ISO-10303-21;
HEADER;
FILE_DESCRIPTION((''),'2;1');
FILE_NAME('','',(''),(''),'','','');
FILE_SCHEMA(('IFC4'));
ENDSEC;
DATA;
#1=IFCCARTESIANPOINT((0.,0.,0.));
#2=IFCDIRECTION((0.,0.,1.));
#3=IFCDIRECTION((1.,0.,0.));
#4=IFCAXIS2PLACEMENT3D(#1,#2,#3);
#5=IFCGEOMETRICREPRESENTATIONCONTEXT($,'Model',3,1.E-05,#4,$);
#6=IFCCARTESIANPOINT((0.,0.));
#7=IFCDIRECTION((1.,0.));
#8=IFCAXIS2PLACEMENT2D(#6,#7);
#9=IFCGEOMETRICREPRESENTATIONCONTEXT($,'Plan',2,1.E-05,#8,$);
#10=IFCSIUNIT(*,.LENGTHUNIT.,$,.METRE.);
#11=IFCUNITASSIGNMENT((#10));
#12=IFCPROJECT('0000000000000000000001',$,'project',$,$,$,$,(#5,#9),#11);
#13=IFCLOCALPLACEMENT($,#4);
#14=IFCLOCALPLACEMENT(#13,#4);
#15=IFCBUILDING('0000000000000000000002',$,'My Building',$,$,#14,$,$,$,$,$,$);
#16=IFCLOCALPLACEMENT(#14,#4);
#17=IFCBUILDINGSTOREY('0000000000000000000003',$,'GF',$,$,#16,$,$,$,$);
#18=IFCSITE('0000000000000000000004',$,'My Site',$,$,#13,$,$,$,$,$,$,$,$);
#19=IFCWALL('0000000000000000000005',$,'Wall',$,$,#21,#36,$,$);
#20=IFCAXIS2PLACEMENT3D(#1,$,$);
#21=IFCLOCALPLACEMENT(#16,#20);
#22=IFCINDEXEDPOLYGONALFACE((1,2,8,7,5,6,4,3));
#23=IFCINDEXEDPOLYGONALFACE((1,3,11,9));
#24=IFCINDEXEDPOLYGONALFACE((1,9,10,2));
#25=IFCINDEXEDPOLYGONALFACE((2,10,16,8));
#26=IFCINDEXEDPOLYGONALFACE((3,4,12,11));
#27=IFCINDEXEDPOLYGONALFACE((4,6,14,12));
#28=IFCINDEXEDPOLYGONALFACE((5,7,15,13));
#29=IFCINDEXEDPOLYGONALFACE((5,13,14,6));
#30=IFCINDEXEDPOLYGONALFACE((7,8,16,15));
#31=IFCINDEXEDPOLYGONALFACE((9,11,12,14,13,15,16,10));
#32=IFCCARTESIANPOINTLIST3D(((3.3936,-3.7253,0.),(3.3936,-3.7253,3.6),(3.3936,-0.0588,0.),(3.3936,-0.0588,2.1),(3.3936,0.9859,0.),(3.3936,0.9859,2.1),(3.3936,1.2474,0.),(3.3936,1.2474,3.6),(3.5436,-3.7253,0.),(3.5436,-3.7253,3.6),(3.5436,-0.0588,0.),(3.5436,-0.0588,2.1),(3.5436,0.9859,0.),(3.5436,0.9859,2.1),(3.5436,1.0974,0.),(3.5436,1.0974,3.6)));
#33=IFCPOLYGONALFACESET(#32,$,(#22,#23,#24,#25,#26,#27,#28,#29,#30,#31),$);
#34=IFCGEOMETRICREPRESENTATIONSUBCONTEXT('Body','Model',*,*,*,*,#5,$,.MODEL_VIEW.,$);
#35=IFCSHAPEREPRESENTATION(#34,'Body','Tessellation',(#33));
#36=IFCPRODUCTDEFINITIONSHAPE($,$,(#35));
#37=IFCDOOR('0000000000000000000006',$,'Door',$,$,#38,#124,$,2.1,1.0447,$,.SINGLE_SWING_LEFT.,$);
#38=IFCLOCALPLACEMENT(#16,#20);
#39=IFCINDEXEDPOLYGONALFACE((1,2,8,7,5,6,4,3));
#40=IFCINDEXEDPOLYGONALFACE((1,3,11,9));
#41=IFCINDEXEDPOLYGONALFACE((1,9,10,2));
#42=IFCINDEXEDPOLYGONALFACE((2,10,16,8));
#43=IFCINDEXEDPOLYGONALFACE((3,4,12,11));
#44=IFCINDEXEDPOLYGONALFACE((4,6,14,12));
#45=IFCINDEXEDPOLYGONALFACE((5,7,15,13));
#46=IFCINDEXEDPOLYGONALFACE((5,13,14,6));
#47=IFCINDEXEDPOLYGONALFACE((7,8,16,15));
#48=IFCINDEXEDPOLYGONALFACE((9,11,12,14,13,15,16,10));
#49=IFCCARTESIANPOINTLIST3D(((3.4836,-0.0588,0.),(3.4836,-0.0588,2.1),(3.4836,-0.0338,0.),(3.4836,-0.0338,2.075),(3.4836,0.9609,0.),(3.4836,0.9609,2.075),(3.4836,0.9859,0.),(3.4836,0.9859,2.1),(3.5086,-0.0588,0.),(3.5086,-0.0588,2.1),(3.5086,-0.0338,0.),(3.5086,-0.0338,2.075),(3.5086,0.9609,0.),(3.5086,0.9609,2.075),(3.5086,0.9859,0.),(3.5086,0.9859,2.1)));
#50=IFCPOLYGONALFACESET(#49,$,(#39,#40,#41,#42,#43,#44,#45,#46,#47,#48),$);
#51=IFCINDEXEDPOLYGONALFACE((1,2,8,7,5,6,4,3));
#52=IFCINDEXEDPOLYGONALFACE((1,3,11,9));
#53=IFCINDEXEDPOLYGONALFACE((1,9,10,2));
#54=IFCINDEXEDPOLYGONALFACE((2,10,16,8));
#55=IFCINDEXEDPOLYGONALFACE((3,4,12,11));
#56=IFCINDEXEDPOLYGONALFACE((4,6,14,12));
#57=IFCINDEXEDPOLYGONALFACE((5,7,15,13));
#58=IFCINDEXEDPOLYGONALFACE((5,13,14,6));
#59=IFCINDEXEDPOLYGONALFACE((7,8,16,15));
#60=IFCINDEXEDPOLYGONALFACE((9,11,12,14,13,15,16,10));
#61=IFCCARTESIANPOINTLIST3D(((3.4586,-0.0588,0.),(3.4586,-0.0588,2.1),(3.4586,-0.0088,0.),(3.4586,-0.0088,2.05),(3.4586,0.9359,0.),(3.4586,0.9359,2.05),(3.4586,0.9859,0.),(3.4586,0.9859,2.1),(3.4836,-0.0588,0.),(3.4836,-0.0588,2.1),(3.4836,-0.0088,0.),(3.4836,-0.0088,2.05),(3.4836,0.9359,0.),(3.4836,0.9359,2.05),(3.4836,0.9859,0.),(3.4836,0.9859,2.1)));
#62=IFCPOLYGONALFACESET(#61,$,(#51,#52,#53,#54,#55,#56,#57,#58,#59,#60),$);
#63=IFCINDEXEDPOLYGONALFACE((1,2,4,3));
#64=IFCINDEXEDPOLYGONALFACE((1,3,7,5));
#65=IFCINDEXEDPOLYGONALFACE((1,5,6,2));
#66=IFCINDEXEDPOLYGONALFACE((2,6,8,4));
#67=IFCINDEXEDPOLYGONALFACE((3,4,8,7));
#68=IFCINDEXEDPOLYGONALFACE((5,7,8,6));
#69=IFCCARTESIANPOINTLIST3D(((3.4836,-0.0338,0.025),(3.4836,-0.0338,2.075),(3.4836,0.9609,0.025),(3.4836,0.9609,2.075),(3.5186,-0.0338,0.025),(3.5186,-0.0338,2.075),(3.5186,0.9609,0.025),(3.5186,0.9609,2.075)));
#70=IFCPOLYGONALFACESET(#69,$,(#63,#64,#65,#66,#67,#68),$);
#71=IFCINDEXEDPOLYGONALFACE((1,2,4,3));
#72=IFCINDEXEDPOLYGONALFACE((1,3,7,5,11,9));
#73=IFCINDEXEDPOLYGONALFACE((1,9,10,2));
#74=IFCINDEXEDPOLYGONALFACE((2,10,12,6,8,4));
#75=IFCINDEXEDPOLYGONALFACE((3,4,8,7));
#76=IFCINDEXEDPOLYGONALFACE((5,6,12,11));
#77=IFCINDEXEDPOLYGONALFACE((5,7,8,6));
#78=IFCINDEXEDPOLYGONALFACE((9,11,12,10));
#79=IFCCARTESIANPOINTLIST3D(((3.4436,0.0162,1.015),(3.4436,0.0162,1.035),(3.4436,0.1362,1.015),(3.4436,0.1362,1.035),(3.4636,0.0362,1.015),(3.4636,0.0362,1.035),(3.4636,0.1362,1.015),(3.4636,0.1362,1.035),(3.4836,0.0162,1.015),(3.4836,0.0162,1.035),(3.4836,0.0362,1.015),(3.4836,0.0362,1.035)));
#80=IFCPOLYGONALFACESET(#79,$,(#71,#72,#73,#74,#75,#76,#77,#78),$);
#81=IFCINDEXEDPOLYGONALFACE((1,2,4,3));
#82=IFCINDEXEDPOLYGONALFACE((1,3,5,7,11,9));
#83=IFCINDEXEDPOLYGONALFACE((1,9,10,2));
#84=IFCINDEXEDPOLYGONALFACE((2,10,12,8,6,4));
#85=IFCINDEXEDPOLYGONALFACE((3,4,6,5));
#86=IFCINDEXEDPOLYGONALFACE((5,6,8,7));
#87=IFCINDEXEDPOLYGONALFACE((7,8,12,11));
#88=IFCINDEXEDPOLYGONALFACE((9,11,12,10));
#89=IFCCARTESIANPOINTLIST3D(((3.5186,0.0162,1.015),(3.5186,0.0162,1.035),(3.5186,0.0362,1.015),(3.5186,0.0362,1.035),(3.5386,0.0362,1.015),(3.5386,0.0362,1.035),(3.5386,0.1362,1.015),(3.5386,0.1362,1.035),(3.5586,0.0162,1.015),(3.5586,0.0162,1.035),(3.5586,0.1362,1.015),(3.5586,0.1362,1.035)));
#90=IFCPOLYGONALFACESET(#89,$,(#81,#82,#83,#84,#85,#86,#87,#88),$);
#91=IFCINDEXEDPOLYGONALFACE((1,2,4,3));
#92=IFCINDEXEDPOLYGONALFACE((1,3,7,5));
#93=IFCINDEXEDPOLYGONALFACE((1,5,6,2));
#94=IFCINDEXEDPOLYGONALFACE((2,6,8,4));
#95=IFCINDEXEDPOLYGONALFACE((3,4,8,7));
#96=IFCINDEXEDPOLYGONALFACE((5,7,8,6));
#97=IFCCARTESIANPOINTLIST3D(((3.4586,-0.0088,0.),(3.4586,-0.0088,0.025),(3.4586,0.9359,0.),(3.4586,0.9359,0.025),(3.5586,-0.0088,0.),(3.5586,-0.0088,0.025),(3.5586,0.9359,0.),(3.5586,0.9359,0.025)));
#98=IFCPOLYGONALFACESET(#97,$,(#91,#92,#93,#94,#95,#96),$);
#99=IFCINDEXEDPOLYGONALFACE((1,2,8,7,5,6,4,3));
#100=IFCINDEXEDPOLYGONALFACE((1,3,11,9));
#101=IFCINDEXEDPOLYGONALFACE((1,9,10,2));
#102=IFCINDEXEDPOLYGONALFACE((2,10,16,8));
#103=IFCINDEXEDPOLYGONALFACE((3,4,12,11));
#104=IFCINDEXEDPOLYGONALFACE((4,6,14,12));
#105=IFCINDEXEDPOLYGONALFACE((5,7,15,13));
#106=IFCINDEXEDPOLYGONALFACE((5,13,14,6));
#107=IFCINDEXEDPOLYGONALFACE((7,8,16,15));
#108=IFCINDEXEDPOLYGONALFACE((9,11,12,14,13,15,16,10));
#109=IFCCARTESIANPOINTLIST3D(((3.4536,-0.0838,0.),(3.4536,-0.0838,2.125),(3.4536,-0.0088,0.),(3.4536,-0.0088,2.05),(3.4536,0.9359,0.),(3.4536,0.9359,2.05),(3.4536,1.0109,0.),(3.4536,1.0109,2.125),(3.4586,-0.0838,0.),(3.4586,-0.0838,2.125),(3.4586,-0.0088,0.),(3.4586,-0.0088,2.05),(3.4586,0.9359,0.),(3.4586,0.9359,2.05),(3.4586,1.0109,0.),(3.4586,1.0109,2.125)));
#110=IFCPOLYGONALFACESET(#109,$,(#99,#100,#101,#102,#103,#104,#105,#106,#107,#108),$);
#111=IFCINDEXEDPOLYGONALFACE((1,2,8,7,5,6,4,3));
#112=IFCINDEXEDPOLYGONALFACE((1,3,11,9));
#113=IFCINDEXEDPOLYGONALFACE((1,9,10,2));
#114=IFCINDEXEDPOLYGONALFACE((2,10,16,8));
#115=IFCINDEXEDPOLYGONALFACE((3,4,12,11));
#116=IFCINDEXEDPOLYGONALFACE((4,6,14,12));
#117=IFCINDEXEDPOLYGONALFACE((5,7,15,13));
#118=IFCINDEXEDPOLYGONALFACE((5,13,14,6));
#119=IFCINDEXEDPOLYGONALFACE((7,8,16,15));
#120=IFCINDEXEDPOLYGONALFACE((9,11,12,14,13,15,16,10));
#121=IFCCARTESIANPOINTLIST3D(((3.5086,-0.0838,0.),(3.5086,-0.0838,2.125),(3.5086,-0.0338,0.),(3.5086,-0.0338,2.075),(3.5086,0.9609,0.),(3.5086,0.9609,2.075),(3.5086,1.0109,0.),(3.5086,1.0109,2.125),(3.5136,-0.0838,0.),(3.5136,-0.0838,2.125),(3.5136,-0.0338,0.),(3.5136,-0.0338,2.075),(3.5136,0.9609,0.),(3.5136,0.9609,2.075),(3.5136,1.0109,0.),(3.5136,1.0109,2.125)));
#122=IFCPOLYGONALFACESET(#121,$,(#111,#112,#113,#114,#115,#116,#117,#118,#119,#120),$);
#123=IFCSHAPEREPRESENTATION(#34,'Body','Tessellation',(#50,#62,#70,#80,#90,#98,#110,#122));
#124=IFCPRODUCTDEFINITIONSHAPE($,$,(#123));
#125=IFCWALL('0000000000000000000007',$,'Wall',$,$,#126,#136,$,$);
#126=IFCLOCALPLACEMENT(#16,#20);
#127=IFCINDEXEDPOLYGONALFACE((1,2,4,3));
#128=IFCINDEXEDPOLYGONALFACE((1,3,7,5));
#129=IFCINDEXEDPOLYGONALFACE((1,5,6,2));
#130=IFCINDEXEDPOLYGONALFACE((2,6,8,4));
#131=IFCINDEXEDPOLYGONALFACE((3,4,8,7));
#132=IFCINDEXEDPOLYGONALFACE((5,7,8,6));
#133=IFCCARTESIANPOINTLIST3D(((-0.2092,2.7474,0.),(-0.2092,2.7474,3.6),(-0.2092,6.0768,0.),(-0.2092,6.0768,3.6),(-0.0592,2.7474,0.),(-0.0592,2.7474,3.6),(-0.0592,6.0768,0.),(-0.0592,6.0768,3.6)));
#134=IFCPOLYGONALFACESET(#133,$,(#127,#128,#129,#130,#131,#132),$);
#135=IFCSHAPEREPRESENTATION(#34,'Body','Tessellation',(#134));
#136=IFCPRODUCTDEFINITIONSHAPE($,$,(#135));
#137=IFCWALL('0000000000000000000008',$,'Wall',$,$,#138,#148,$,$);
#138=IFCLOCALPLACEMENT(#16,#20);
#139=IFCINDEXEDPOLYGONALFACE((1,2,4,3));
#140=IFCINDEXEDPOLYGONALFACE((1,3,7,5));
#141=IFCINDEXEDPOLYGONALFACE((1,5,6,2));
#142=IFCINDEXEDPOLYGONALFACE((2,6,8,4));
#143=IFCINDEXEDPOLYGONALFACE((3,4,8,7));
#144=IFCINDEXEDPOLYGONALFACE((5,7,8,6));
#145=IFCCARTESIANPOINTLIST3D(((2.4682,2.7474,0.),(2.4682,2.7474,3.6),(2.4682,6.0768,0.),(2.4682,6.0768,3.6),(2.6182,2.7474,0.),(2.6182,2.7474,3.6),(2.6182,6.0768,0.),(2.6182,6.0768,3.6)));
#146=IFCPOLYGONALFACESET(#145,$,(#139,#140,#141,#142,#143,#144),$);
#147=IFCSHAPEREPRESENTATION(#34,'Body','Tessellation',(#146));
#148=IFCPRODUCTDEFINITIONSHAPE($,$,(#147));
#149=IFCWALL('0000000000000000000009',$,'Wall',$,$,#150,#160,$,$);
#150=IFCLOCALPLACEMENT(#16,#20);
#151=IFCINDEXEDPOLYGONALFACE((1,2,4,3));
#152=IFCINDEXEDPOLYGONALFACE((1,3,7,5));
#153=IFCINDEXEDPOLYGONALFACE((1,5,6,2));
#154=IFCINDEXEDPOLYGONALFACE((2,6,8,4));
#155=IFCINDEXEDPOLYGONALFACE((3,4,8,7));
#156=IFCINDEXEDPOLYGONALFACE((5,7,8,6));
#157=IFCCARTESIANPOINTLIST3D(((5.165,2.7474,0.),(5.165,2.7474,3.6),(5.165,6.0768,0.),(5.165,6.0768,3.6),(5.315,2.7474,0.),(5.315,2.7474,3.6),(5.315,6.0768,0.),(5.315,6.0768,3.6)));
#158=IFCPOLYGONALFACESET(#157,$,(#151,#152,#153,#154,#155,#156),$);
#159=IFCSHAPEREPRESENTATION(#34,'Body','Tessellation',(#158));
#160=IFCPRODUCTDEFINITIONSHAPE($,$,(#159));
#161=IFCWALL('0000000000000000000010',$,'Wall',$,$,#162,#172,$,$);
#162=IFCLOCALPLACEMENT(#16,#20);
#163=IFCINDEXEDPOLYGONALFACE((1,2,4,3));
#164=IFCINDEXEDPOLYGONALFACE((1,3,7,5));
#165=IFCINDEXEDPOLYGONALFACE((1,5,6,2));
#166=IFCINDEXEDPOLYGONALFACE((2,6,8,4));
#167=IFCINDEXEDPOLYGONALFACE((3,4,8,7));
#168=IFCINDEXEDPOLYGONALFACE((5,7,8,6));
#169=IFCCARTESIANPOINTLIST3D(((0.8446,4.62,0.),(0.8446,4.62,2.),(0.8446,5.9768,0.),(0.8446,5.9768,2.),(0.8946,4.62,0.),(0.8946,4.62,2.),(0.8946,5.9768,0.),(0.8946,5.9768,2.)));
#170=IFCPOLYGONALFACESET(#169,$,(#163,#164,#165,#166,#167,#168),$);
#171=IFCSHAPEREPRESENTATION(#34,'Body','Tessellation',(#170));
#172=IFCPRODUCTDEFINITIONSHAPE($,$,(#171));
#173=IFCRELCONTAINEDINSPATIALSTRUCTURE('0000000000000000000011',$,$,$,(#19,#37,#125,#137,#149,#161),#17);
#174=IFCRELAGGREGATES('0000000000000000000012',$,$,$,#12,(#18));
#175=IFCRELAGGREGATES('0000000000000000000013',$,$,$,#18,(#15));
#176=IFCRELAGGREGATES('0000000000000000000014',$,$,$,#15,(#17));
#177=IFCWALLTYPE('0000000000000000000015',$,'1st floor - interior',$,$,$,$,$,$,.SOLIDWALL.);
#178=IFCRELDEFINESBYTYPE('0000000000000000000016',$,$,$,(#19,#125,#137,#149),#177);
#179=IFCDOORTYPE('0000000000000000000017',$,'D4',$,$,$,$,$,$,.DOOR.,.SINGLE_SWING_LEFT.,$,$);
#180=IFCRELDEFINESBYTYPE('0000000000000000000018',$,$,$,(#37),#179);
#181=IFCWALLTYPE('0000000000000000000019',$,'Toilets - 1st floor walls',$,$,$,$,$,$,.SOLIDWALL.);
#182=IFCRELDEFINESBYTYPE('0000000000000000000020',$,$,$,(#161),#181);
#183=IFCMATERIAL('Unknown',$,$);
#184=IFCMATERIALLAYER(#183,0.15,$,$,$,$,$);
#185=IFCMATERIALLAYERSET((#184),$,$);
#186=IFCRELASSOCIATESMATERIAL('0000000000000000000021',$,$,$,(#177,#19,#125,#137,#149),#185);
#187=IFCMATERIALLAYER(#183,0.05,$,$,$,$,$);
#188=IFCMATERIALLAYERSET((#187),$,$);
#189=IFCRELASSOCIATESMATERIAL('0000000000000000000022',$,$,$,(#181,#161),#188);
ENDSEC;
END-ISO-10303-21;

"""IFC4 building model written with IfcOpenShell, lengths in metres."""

from ifc_helpers import new_model, entity, si_unit, frame, origin_with_axes, origin_2d_with_axis, place, context, subcontext, project, spatial, line, indexed_curve, outline, extrude, shape, source, transform, mapped, material, layer, layer_set, layer_usage, type_object, type_shapes, element, fill, save


model = new_model("IFC4")

# Units and contexts
model_context = context("Model", 3, precision=1e-05, world=origin_with_axes())
plan_context = context("Plan", 2, precision=1e-05, world=origin_2d_with_axis())
body_context_1 = subcontext(model_context, "Body", "Model", "MODEL_VIEW")
body_context_2 = subcontext(plan_context, "Body", "Plan", "PLAN_VIEW")
ifc_project = project(units=[si_unit("LENGTHUNIT", "METRE")], contexts=[model_context, plan_context])

# Site, building, storey
site_placement = place(None, origin_with_axes())
site = spatial("IfcSite", under=ifc_project, at=site_placement, Name="My Site")
building_placement = place(site_placement, origin_with_axes())
building = spatial("IfcBuilding", under=site, at=building_placement, Name="My Building")
storey_placement = place(building_placement, origin_with_axes())
storey = spatial("IfcBuildingStorey", under=building, at=storey_placement, Name="GF")

# Shared definitions
ifc_material = material(Name="Unknown")

# Shared definitions
ifc_layer_1 = layer(ifc_material, 0.15)
ifc_layer_set_1 = layer_set([ifc_layer_1])
wall_type_1 = type_object("IfcWallType", Name="1st floor - interior", PredefinedType="SOLIDWALL", material=ifc_layer_set_1)

# Wall, opening, door
ifc_layer_usage_1 = layer_usage(ifc_layer_set_1, "AXIS2", "POSITIVE", 0.0)
wall_1_placement = place(storey_placement, frame((3.3936, 1.2474, 0.0), z_axis=(0.0, 0.0, 1.0), x_axis=(0.0, -1.0, 0.0)))
wall_1 = element("IfcWall", 1, at=wall_1_placement, inside=storey, type_object=wall_type_1, material=ifc_layer_usage_1, Name="Wall", context=body_context_1, shape_type="SweptSolid", body=[
    extrude(outline(indexed_curve([(0.0, 0.0), (0.15, 0.15), (4.9727, 0.15), (4.9727, 0.0)], segments=[line(1, 2, 3, 4, 1)])), origin_with_axes(), (0.0, 0.0, 1.0), 3.6),
])
shared_shape_1 = source(origin_with_axes(), body_context_1, "Body", "SweptSolid", [
    extrude(outline(indexed_curve([(0.0, 0.0), (1.0447, 0.0), (1.0447, 2.1), (0.0, 2.1)], segments=[line(1, 2, 3, 4, 1)])), frame((0.0, -0.6, 0.0), z_axis=(0.0, -1.0, 0.0), x_axis=(1.0, 0.0, 0.0)), (0.0, 0.0, -1.0), 1.2),
])
opening_1_placement = place(wall_1_placement, frame((0.2615, 0.065, 0.0), z_axis=(0.0, 0.0, 1.0), x_axis=(1.0, 0.0, 0.0)))
opening_1 = element("IfcOpeningElement", 2, at=opening_1_placement, cuts=wall_1, PredefinedType="OPENING", context=body_context_1, shape_type="MappedRepresentation", body=[
    mapped(shared_shape_1, transform((0.0, 0.0, 0.0), x_axis=(1.0, 0.0, 0.0), y_axis=(0.0, 1.0, 0.0), z_axis=(0.0, 0.0, 1.0), scale=1.0)),
])
door_type_1 = type_object("IfcDoorType", Name="D4", OperationType="SINGLE_SWING_LEFT", PredefinedType="DOOR")
shared_shape_2 = source(origin_with_axes(), body_context_1, "Body", "SweptSolid", [
    extrude(outline(indexed_curve([(0.0, 0.0), (0.0, 2.1), (1.0447, 2.1), (1.0447, 0.0), (1.0197, 0.0), (1.0197, 2.075), (0.025, 2.075), (0.025, 0.0)], segments=[line(1, 2, 3, 4, 5, 6, 7, 8, 1)])), frame((0.0, 0.025, 0.0), z_axis=(0.0, -1.0, 0.0), x_axis=(1.0, 0.0, 0.0)), (0.0, 0.0, -1.0), 0.025),
    extrude(outline(indexed_curve([(0.0, 0.0), (0.0, 2.1), (1.0447, 2.1), (1.0447, 0.0), (0.9947, 0.0), (0.9947, 2.05), (0.05, 2.05), (0.05, 0.0)], segments=[line(1, 2, 3, 4, 5, 6, 7, 8, 1)])), frame((0.0, 0.0, 0.0), z_axis=(0.0, -1.0, 0.0), x_axis=(1.0, 0.0, 0.0)), (0.0, 0.0, -1.0), 0.025),
    extrude(outline(indexed_curve([(0.0, 0.0), (0.9947, 0.0), (0.9947, 0.035), (0.0, 0.035)], segments=[line(1, 2, 3, 4, 1)])), frame((0.025, 0.025, 0.025), z_axis=(0.0, 0.0, 1.0), x_axis=(1.0, 0.0, 0.0)), (0.0, 0.0, 1.0), 2.05),
    extrude(outline(indexed_curve([(0.0, 0.0), (0.0, -0.04), (-0.12, -0.04), (-0.12, -0.02), (-0.02, -0.02), (-0.02, 0.0)], segments=[line(1, 2, 3, 4, 5, 6, 1)])), frame((0.9697, 0.025, 1.015), z_axis=(0.0, 0.0, 1.0), x_axis=(1.0, 0.0, 0.0)), (0.0, 0.0, 1.0), 0.02),
    extrude(outline(indexed_curve([(0.0, 0.0), (0.0, 0.04), (-0.12, 0.04), (-0.12, 0.02), (-0.02, 0.02), (-0.02, 0.0)], segments=[line(1, 2, 3, 4, 5, 6, 1)])), frame((0.9697, 0.06, 1.015), z_axis=(0.0, 0.0, 1.0), x_axis=(1.0, 0.0, 0.0)), (0.0, 0.0, 1.0), 0.02),
    extrude(outline(indexed_curve([(0.0, 0.0), (0.9447, 0.0), (0.9447, 0.1), (0.0, 0.1)], segments=[line(1, 2, 3, 4, 1)])), frame((0.05, 0.0, 0.0), z_axis=(0.0, 0.0, 1.0), x_axis=(1.0, 0.0, 0.0)), (0.0, 0.0, 1.0), 0.025),
    extrude(outline(indexed_curve([(0.0, 0.0), (0.0, 2.125), (1.0947, 2.125), (1.0947, 0.0), (1.0197, 0.0), (1.0197, 2.05), (0.075, 2.05), (0.075, 0.0)], segments=[line(1, 2, 3, 4, 5, 6, 7, 8, 1)])), frame((-0.025, -0.005, 0.0), z_axis=(0.0, -1.0, 0.0), x_axis=(1.0, 0.0, 0.0)), (0.0, 0.0, -1.0), 0.005),
    extrude(outline(indexed_curve([(0.0, 0.0), (0.0, 2.125), (1.0947, 2.125), (1.0947, 0.0), (1.0447, 0.0), (1.0447, 2.075), (0.05, 2.075), (0.05, 0.0)], segments=[line(1, 2, 3, 4, 5, 6, 7, 8, 1)])), frame((-0.025, 0.05, 0.0), z_axis=(0.0, -1.0, 0.0), x_axis=(1.0, 0.0, 0.0)), (0.0, 0.0, -1.0), 0.005),
])
shared_shape_3 = source(origin_with_axes(), body_context_2, "Body", "Curve2D", [
    entity("IfcIndexedPolyCurve", entity("IfcCartesianPointList2D", [[0.0, 0.0], [0.0, 0.05], [0.025, 0.05], [0.025, 0.025], [0.05, 0.025], [0.05, 0.0]]), [entity("IfcLineIndex", [1, 2, 3, 4, 5, 6, 1])]),
    entity("IfcIndexedPolyCurve", entity("IfcCartesianPointList2D", [[1.0447, 0.0], [1.0447, 0.05], [1.0197, 0.05], [1.0197, 0.025], [0.9947, 0.025], [0.9947, 0.0]]), [entity("IfcLineIndex", [1, 2, 3, 4, 5, 6, 1])]),
    entity("IfcTrimmedCurve", entity("IfcEllipse", entity("IfcAxis2Placement2D", entity("IfcCartesianPoint", [0.06, 0.05]), entity("IfcDirection", [1.0, 0.0])), 0.9597, 0.9947), [entity("IfcCartesianPoint", [1.0197, 0.05])], [entity("IfcCartesianPoint", [0.06, 1.0447])], True, "CARTESIAN"),
    entity("IfcIndexedPolyCurve", entity("IfcCartesianPointList2D", [[0.025, 0.05], [0.06, 0.05], [0.06, 1.0447], [0.025, 1.0447]]), [entity("IfcLineIndex", [1, 2, 3, 4, 1])]),
])
type_shapes(door_type_1, [shared_shape_2, shared_shape_3])
door_1_placement = place(opening_1_placement, frame((0.0, 0.0, 0.0), z_axis=(0.0, 0.0, 1.0), x_axis=(1.0, 0.0, 0.0)))
door_1 = element("IfcDoor", 3, at=door_1_placement, inside=storey, type_object=door_type_1, Name="Door", OperationType="SINGLE_SWING_LEFT", OverallHeight=2.1, OverallWidth=1.0447, shapes=[
    shape(body_context_1, "Body", "MappedRepresentation", [mapped(shared_shape_2, transform((0.0, 0.0, 0.0), x_axis=(1.0, 0.0, 0.0), y_axis=(0.0, 1.0, 0.0), z_axis=(0.0, 0.0, 1.0), scale=1.0))]),
    shape(body_context_2, "Body", "MappedRepresentation", [mapped(shared_shape_3, transform((0.0, 0.0, 0.0), x_axis=(1.0, 0.0, 0.0), y_axis=(0.0, 1.0, 0.0), z_axis=(0.0, 0.0, 1.0), scale=1.0))]),
])
fill(opening_1, door_1)

# Walls
ifc_layer_usage_2 = layer_usage(ifc_layer_set_1, "AXIS2", "POSITIVE", 0.0)
wall_2_placement = place(storey_placement, frame((-0.2092, 6.0768, 0.0), z_axis=(0.0, 0.0, 1.0), x_axis=(0.0, -1.0, 0.0)))
element("IfcWall", 4, at=wall_2_placement, inside=storey, type_object=wall_type_1, material=ifc_layer_usage_2, Name="Wall", context=body_context_1, shape_type="SweptSolid", body=[
    extrude(outline(indexed_curve([(0.0, 0.0), (0.0, 0.15), (3.3293, 0.15), (3.3293, 0.0)], segments=[line(1, 2, 3, 4, 1)])), origin_with_axes(), (0.0, 0.0, 1.0), 3.6),
])
ifc_layer_usage_3 = layer_usage(ifc_layer_set_1, "AXIS2", "POSITIVE", 0.0)
wall_3_placement = place(storey_placement, frame((2.4682, 6.0768, 0.0), z_axis=(0.0, 0.0, 1.0), x_axis=(0.0, -1.0, 0.0)))
element("IfcWall", 5, at=wall_3_placement, inside=storey, type_object=wall_type_1, material=ifc_layer_usage_3, Name="Wall", context=body_context_1, shape_type="SweptSolid", body=[
    extrude(outline(indexed_curve([(0.0, 0.0), (0.0, 0.15), (3.3293, 0.15), (3.3293, 0.0)], segments=[line(1, 2, 3, 4, 1)])), origin_with_axes(), (0.0, 0.0, 1.0), 3.6),
])
ifc_layer_usage_4 = layer_usage(ifc_layer_set_1, "AXIS2", "POSITIVE", 0.0)
wall_4_placement = place(storey_placement, frame((5.165, 6.0768, 0.0), z_axis=(0.0, 0.0, 1.0), x_axis=(0.0, -1.0, 0.0)))
element("IfcWall", 6, at=wall_4_placement, inside=storey, type_object=wall_type_1, material=ifc_layer_usage_4, Name="Wall", context=body_context_1, shape_type="SweptSolid", body=[
    extrude(outline(indexed_curve([(0.0, 0.0), (0.0, 0.15), (3.3293, 0.15), (3.3293, 0.0)], segments=[line(1, 2, 3, 4, 1)])), origin_with_axes(), (0.0, 0.0, 1.0), 3.6),
])
ifc_layer_2 = layer(ifc_material, 0.05)
ifc_layer_set_2 = layer_set([ifc_layer_2])
ifc_layer_usage_5 = layer_usage(ifc_layer_set_2, "AXIS2", "POSITIVE", 0.0)
wall_type_2 = type_object("IfcWallType", Name="Toilets - 1st floor walls", PredefinedType="SOLIDWALL", material=ifc_layer_set_2)
wall_5_placement = place(storey_placement, frame((0.8446, 5.9768, 0.0), z_axis=(0.0, 0.0, 1.0), x_axis=(0.0, -1.0, 0.0)))
element("IfcWall", 7, at=wall_5_placement, inside=storey, type_object=wall_type_2, material=ifc_layer_usage_5, Name="Wall", context=body_context_1, shape_type="SweptSolid", body=[
    extrude(outline(indexed_curve([(0.0, 0.0), (0.0, 0.05), (1.3568, 0.05), (1.3568, 0.0)], segments=[line(1, 2, 3, 4, 1)])), origin_with_axes(), (0.0, 0.0, 1.0), 2.0),
])

save(model, "model.ifc")
